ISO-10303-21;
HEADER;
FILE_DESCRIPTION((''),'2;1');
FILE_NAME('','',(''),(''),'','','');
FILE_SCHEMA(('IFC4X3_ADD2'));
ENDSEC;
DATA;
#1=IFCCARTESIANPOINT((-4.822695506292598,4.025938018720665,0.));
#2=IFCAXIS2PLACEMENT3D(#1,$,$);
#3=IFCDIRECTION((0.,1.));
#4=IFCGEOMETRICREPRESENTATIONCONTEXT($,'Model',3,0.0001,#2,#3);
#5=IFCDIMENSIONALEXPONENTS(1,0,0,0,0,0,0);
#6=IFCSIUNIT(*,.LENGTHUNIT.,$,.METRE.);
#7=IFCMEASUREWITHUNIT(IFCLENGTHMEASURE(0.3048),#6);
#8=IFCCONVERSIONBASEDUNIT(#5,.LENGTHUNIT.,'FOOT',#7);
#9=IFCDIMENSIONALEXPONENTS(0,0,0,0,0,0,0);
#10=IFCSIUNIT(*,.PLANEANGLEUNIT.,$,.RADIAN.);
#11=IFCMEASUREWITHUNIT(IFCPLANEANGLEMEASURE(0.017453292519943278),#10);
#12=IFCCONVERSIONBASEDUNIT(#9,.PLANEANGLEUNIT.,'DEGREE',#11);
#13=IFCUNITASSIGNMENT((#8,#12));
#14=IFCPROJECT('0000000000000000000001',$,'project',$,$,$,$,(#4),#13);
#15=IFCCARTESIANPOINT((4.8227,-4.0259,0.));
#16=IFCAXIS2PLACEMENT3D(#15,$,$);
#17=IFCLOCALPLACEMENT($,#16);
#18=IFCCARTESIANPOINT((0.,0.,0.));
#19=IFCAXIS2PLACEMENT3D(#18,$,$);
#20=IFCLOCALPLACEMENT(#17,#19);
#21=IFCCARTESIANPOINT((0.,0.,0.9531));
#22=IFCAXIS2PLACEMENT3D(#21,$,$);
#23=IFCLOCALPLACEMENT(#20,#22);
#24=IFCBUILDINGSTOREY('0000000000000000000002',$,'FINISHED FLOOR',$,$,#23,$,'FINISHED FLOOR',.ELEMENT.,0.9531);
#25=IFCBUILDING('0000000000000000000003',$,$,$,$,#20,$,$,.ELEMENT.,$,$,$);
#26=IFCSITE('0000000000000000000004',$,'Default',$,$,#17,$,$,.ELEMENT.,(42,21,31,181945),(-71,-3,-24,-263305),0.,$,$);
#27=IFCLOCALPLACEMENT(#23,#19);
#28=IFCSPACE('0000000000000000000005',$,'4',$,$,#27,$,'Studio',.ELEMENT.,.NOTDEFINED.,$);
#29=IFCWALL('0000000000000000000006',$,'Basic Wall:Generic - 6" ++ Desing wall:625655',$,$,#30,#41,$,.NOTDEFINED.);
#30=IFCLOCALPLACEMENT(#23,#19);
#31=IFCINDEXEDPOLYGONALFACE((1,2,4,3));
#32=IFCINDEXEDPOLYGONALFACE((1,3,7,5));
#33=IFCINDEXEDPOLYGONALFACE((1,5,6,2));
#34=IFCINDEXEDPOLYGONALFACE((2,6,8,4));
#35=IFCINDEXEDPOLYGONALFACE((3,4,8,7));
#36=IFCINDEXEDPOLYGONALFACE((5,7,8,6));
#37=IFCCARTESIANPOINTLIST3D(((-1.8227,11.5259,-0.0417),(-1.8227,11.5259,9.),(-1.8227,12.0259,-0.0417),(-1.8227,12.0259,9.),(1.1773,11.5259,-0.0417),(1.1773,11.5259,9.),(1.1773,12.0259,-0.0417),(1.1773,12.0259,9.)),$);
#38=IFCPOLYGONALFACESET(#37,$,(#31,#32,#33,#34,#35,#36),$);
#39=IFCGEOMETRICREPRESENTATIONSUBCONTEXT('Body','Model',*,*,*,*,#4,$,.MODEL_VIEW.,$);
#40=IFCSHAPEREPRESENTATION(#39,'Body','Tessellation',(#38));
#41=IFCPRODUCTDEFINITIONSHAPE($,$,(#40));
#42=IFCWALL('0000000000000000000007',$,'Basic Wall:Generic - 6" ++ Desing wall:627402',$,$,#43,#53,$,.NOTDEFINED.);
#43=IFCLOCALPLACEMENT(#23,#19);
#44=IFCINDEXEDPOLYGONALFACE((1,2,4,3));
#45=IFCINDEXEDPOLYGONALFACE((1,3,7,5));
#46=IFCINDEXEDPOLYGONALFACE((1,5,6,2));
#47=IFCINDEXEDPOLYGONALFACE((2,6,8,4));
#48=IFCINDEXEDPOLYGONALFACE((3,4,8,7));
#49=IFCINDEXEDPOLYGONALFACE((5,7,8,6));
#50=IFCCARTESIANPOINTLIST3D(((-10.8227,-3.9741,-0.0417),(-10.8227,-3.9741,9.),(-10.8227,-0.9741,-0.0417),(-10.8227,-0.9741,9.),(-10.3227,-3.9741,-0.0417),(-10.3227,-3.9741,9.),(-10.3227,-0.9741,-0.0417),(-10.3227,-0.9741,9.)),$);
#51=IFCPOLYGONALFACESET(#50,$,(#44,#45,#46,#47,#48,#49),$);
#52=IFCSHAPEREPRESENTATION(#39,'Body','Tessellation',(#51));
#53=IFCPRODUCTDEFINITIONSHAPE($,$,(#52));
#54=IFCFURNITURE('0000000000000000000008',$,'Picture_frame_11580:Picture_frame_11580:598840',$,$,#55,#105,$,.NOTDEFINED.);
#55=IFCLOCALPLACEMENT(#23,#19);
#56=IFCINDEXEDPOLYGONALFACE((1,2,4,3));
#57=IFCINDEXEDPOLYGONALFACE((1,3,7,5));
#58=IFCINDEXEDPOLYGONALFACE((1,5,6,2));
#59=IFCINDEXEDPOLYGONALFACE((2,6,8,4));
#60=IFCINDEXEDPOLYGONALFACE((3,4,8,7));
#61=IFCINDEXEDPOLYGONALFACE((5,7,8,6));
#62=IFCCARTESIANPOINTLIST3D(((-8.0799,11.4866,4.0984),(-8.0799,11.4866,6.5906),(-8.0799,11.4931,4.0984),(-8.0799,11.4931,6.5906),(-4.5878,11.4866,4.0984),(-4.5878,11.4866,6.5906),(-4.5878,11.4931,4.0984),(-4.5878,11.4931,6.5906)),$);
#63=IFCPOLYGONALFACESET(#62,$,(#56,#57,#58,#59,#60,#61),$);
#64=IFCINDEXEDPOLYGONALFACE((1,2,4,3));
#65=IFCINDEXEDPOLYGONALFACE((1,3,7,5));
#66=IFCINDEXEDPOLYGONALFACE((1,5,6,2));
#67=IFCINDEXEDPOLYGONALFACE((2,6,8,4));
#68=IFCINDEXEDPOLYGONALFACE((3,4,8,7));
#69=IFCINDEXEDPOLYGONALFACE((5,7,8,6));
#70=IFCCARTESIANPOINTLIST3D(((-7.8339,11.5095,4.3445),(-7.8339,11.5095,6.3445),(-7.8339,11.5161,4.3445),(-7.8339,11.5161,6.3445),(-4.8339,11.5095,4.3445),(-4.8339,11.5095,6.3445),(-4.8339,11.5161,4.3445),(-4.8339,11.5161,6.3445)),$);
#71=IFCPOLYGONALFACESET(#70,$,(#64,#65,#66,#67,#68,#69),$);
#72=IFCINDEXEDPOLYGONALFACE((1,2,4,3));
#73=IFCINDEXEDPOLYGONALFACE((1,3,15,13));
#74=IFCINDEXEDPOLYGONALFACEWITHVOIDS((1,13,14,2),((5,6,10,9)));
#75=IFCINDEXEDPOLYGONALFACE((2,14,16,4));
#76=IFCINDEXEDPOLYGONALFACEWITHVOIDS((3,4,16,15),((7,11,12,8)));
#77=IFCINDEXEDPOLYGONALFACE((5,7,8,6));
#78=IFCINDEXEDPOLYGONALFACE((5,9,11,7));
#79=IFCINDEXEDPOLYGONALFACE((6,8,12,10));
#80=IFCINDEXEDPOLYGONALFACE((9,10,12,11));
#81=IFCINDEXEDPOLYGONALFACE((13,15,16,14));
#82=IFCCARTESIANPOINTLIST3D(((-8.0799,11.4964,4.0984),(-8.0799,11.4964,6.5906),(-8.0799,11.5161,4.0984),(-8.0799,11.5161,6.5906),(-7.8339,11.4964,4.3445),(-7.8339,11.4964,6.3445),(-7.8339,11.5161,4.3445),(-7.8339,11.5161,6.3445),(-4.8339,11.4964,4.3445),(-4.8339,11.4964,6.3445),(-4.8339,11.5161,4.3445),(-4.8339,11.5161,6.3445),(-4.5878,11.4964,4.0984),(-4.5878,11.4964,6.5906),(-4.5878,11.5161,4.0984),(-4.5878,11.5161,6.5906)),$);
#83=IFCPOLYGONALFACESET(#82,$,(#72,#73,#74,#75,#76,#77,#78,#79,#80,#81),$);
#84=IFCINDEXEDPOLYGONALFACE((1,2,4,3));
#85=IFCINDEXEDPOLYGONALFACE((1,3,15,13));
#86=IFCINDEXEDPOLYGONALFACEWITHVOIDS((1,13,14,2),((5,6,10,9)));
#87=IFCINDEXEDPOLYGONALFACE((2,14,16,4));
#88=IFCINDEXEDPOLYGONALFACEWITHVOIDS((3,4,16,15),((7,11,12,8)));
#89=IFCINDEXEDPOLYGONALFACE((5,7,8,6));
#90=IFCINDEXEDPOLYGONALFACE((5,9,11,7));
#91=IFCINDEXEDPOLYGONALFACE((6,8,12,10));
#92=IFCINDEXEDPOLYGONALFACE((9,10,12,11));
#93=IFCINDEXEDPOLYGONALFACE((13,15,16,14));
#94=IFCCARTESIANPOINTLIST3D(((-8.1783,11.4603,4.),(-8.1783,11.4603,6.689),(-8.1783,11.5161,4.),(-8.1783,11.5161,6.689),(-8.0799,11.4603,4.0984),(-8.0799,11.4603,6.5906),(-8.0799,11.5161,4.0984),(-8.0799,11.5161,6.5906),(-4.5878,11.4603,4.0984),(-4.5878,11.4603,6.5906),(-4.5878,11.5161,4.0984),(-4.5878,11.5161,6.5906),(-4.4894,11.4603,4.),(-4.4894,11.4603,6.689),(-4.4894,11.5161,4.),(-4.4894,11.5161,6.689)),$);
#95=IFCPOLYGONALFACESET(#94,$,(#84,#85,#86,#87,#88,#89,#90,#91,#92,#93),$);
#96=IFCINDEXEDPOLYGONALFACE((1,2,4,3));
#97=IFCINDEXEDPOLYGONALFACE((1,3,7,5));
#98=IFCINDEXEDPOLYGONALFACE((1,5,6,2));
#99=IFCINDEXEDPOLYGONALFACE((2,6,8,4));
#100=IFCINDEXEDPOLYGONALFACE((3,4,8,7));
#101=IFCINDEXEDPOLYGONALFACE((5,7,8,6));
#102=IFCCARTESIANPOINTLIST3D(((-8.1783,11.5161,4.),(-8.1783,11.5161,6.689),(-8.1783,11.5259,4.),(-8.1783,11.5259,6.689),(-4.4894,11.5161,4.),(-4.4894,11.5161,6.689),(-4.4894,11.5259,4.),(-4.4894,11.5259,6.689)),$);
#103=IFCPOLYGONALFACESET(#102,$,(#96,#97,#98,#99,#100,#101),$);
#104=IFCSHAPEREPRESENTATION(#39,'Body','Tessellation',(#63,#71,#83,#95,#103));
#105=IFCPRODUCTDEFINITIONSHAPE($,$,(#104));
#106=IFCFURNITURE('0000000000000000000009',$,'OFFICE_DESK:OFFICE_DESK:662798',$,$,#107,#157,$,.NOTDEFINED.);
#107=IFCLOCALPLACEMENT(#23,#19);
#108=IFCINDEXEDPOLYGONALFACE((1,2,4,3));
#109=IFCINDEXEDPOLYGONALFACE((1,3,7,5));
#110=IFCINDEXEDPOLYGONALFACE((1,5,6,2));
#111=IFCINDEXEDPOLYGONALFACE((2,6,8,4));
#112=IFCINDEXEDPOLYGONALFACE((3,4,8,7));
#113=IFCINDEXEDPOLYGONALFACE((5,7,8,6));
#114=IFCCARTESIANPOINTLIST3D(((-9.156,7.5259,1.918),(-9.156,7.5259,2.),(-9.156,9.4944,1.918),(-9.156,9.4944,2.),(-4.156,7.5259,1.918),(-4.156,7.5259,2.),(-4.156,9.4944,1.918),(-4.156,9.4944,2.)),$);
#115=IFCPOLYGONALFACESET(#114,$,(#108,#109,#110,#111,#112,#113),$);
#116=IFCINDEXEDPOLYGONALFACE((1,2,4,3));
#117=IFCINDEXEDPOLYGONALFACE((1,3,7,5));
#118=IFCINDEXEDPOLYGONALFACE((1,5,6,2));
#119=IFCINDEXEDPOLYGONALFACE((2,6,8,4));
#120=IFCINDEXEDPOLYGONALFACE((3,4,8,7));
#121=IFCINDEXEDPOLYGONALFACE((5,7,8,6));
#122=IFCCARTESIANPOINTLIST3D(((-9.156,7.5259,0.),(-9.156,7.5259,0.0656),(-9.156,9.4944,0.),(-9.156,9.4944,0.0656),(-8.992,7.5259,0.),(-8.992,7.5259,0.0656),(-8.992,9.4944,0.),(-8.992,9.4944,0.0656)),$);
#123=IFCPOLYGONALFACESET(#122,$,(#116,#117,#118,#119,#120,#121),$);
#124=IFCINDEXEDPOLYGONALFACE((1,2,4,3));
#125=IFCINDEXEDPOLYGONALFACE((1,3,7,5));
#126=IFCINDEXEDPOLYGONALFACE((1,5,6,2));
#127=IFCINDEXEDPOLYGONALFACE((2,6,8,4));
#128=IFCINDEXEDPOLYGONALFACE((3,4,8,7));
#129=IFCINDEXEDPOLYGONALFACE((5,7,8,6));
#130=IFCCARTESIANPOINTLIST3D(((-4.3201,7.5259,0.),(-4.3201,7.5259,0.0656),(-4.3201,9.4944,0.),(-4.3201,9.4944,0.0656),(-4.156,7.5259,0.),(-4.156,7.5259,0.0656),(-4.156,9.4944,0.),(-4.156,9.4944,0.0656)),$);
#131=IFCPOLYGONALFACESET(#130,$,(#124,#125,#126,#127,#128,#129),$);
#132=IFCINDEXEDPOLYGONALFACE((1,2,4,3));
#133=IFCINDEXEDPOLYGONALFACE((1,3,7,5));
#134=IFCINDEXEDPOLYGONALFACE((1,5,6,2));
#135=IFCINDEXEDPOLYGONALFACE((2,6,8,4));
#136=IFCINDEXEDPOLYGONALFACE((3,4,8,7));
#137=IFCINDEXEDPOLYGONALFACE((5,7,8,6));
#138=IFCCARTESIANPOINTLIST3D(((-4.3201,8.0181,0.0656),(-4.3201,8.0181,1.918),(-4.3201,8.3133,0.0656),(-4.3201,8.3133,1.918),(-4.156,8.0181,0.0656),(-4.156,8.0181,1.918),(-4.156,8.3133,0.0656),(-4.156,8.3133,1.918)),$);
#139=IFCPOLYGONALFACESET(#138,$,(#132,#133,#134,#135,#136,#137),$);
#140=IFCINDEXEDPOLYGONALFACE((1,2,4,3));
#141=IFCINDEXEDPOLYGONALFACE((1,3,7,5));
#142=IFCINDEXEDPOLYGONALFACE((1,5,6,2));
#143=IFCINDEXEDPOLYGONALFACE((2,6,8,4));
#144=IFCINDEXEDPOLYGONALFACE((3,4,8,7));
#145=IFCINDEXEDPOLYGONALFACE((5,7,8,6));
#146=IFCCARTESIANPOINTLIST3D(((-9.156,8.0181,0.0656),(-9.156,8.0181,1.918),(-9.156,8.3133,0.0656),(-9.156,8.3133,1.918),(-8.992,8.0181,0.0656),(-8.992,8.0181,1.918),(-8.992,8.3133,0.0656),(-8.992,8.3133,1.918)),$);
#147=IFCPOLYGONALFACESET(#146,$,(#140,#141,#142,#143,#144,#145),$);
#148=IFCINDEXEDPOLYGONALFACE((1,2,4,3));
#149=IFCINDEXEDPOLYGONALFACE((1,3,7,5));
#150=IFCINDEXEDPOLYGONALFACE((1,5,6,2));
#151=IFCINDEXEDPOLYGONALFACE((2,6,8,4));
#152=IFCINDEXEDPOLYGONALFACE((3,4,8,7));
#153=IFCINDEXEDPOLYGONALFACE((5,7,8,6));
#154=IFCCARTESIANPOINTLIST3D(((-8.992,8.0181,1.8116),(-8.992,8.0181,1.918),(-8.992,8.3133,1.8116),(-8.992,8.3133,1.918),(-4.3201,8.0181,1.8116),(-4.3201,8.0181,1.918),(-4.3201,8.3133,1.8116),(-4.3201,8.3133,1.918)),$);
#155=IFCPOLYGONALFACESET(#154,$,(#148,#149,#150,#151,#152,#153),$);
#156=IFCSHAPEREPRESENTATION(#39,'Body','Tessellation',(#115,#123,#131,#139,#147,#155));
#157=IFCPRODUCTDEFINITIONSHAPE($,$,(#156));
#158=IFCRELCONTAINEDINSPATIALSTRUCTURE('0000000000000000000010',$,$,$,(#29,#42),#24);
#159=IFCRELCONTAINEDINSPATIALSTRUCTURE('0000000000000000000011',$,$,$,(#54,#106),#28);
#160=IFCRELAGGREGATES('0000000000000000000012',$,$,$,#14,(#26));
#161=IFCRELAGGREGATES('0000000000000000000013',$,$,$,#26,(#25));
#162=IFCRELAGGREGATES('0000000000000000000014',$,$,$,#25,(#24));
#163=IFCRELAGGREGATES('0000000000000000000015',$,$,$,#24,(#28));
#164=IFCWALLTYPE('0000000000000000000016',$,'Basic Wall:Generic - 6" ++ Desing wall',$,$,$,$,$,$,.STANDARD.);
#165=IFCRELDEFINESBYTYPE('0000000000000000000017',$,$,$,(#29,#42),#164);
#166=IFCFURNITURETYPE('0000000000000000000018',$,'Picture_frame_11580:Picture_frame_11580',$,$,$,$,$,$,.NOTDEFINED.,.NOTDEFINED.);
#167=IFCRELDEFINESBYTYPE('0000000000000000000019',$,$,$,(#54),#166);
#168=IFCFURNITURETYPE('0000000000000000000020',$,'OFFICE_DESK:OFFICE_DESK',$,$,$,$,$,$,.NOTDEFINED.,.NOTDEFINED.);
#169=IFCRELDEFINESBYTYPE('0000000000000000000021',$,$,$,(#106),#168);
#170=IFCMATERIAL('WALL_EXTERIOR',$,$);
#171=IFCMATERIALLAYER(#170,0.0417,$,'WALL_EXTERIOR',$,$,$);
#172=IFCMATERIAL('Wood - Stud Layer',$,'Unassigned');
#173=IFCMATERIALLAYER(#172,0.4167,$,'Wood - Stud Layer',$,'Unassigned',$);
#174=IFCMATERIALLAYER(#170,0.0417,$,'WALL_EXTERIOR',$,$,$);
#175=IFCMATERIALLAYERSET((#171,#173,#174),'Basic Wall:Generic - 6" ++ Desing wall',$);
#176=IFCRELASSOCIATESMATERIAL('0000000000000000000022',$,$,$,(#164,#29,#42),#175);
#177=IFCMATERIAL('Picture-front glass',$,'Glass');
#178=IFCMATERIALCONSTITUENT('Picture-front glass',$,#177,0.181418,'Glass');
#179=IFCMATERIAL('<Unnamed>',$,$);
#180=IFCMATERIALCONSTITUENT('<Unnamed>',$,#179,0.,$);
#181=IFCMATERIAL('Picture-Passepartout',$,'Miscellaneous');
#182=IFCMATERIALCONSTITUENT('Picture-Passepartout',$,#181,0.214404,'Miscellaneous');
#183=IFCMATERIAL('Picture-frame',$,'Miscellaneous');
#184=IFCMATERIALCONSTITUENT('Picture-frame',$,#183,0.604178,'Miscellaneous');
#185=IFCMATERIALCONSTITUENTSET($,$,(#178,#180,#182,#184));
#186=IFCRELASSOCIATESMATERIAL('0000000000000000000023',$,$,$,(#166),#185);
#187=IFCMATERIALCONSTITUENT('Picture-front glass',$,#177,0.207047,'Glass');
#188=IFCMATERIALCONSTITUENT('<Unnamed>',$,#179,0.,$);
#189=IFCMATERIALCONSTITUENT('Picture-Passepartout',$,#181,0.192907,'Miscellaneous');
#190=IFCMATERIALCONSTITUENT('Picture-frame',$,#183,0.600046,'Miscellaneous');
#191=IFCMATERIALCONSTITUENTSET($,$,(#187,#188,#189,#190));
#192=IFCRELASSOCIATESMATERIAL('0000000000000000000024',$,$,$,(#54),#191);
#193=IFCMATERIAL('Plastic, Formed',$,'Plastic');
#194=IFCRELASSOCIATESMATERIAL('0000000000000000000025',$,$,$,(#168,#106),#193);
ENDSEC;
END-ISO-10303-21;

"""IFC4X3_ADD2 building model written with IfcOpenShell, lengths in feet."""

from ifc_helpers import new_model, entity, si_unit, converted_unit, direction, frame, frame_2d, origin, origin_2d_with_axis, place, context, subcontext, project, spatial, polyline, rectangle, outline, extrude, source, transform, mapped, material, layer, layer_set, constituent, constituent_set, type_object, type_shapes, element, save


model = new_model("IFC4X3_ADD2")

# Units and contexts
model_context = context("Model", 3, precision=0.0001, world=frame((-4.822695506292598, 4.025938018720665, 0.0)), true_north=direction((0.0, 1.0)))
body_context = subcontext(model_context, "Body", "Model", "MODEL_VIEW")
ifc_project = project(units=[converted_unit("LENGTHUNIT", "FOOT", entity("IfcLengthMeasure", 0.3048), si_unit("LENGTHUNIT", "METRE"), dimensions=[1, 0, 0, 0, 0, 0, 0]), converted_unit("PLANEANGLEUNIT", "DEGREE", entity("IfcPlaneAngleMeasure", 0.017453292519943278), si_unit("PLANEANGLEUNIT", "RADIAN"), dimensions=[0, 0, 0, 0, 0, 0, 0])], contexts=[model_context])

# Site, building, storey
site_placement = place(None, frame((4.8227, -4.0259, 0.0)))
site = spatial("IfcSite", under=ifc_project, at=site_placement, Name="Default", CompositionType="ELEMENT", RefLatitude=(42, 21, 31, 181945), RefLongitude=(-71, -3, -24, -263305), RefElevation=0.0)
building_placement = place(site_placement, origin())
building = spatial("IfcBuilding", under=site, at=building_placement, CompositionType="ELEMENT")
storey_placement = place(building_placement, frame((0.0, 0.0, 0.9531)))
storey = spatial("IfcBuildingStorey", under=building, at=storey_placement, Name="FINISHED FLOOR", LongName="FINISHED FLOOR", CompositionType="ELEMENT", Elevation=0.9531)

# Shared definitions
ifc_material_1 = material(Name="WALL_EXTERIOR")
ifc_material_2 = material(Name="Wood - Stud Layer", Category="Unassigned")

# Walls
ifc_layer_1 = layer(ifc_material_1, 0.0417, Name="WALL_EXTERIOR")
ifc_layer_2 = layer(ifc_material_2, 0.4167, Name="Wood - Stud Layer", Category="Unassigned")
ifc_layer_3 = layer(ifc_material_1, 0.0417, Name="WALL_EXTERIOR")
ifc_layer_set_1 = layer_set([ifc_layer_1, ifc_layer_2, ifc_layer_3], Name="Basic Wall:Generic - 6\" ++ Desing wall")
wall_type_1 = type_object("IfcWallType", Name="Basic Wall:Generic - 6\" ++ Desing wall", PredefinedType="STANDARD", material=ifc_layer_set_1)
wall_1_placement = place(storey_placement, frame((-1.8227, 11.7759, -0.0417)))
element("IfcWall", 1, at=wall_1_placement, inside=storey, type_object=wall_type_1, material=ifc_layer_set_1, Name="Basic Wall:Generic - 6\" ++ Desing wall:625655", PredefinedType="NOTDEFINED", context=body_context, shape_type="SweptSolid", body=[
    extrude(rectangle(XDim=3.0, YDim=0.5, at=frame_2d((1.5, 0.0), x_axis=(-1.0, 0.0))), origin(), (0.0, 0.0, 1.0), 9.0417),
])
wall_2_placement = place(storey_placement, frame((-10.5727, -0.9741, -0.0417), z_axis=(0.0, 0.0, 1.0), x_axis=(0.0, -1.0, 0.0)))
element("IfcWall", 2, at=wall_2_placement, inside=storey, type_object=wall_type_1, material=ifc_layer_set_1, Name="Basic Wall:Generic - 6\" ++ Desing wall:627402", PredefinedType="NOTDEFINED", context=body_context, shape_type="SweptSolid", body=[
    extrude(rectangle(XDim=3.0, YDim=0.5, at=frame_2d((1.5, 0.0), x_axis=(-1.0, 0.0))), origin(), (0.0, 0.0, 1.0), 9.0417),
])

# Shared definitions
space_placement = place(storey_placement, origin())
space = spatial("IfcSpace", under=storey, at=space_placement, Name="4", LongName="Studio", CompositionType="ELEMENT", PredefinedType="NOTDEFINED")

# Furniture
ifc_material_3 = material(Name="Picture-front glass", Category="Glass")
ifc_constituent_1 = constituent(ifc_material_3, Name="Picture-front glass", Category="Glass", fraction=0.207047)
ifc_material_4 = material(Name="<Unnamed>")
ifc_constituent_2 = constituent(ifc_material_4, Name="<Unnamed>", fraction=0.0)
ifc_material_5 = material(Name="Picture-Passepartout", Category="Miscellaneous")
ifc_constituent_3 = constituent(ifc_material_5, Name="Picture-Passepartout", Category="Miscellaneous", fraction=0.192907)
ifc_material_6 = material(Name="Picture-frame", Category="Miscellaneous")
ifc_constituent_4 = constituent(ifc_material_6, Name="Picture-frame", Category="Miscellaneous", fraction=0.600046)
ifc_constituent_set_1 = constituent_set(constituents=[ifc_constituent_1, ifc_constituent_2, ifc_constituent_3, ifc_constituent_4])
ifc_constituent_5 = constituent(ifc_material_3, Name="Picture-front glass", Category="Glass", fraction=0.181418)
ifc_constituent_6 = constituent(ifc_material_4, Name="<Unnamed>", fraction=0.0)
ifc_constituent_7 = constituent(ifc_material_5, Name="Picture-Passepartout", Category="Miscellaneous", fraction=0.214404)
ifc_constituent_8 = constituent(ifc_material_6, Name="Picture-frame", Category="Miscellaneous", fraction=0.604178)
ifc_constituent_set_2 = constituent_set(constituents=[ifc_constituent_5, ifc_constituent_6, ifc_constituent_7, ifc_constituent_8])
furniture_type_1 = type_object("IfcFurnitureType", Name="Picture_frame_11580:Picture_frame_11580", AssemblyPlace="NOTDEFINED", PredefinedType="NOTDEFINED", material=ifc_constituent_set_2)
shared_shape_1 = source(origin(), body_context, "Body", "SweptSolid", [
    extrude(rectangle(XDim=0.0066, YDim=3.4921, at=frame_2d((0.0, 0.0), x_axis=(1.0, 0.0))), frame((1.8445, -0.0361, 0.0984), z_axis=(0.0, 0.0, 1.0), x_axis=(0.0, 1.0, 0.0)), (0.0, 0.0, 1.0), 2.4921),
    extrude(rectangle(XDim=0.0066, YDim=3.0, at=origin_2d_with_axis()), frame((1.8445, -0.0131, 0.3445), z_axis=(0.0, 0.0, 1.0), x_axis=(0.0, 1.0, 0.0)), (0.0, 0.0, 1.0), 2.0),
    extrude(outline(polyline([(-1.2461, -1.7461), (1.2461, -1.7461), (1.2461, 1.7461), (-1.2461, 1.7461), (-1.2461, -1.7461)]), holes=[polyline([(-1.0, -1.5), (-1.0, 1.5), (1.0, 1.5), (1.0, -1.5), (-1.0, -1.5)])]), frame((1.8445, -0.0295, 1.3445), z_axis=(0.0, 1.0, 0.0), x_axis=(0.0, 0.0, -1.0)), (0.0, 0.0, 1.0), 0.0197),
    extrude(outline(polyline([(-1.8445, -1.3445), (1.8445, -1.3445), (1.8445, 1.3445), (-1.8445, 1.3445), (-1.8445, -1.3445)]), holes=[polyline([(1.7461, -1.2461), (-1.7461, -1.2461), (-1.7461, 1.2461), (1.7461, 1.2461), (1.7461, -1.2461)])]), frame((1.8445, -0.0656, 1.3445), z_axis=(0.0, 1.0, 0.0), x_axis=(1.0, 0.0, 0.0)), (0.0, 0.0, 1.0), 0.0558),
    extrude(rectangle(XDim=0.0098, YDim=3.689, at=origin_2d_with_axis()), frame((1.8445, -0.0049, 0.0), z_axis=(0.0, 0.0, 1.0), x_axis=(0.0, 1.0, 0.0)), (0.0, 0.0, 1.0), 2.689),
])
type_shapes(furniture_type_1, [shared_shape_1])
furniture_1_placement = place(space_placement, frame((-8.1783, 11.5259, 4.0)))
element("IfcFurniture", 3, at=furniture_1_placement, inside=space, type_object=furniture_type_1, material=ifc_constituent_set_1, Name="Picture_frame_11580:Picture_frame_11580:598840", PredefinedType="NOTDEFINED", context=body_context, shape_type="MappedRepresentation", body=[
    mapped(shared_shape_1, transform((0.0, 0.0, 0.0), scale=1.0)),
])
ifc_material_7 = material(Name="Plastic, Formed", Category="Plastic")
furniture_type_2 = type_object("IfcFurnitureType", Name="OFFICE_DESK:OFFICE_DESK", AssemblyPlace="NOTDEFINED", PredefinedType="NOTDEFINED", material=ifc_material_7)
shared_shape_2 = source(origin(), body_context, "Body", "SweptSolid", [
    extrude(rectangle(XDim=1.9685, YDim=5.0, at=origin_2d_with_axis()), frame((0.0, -0.9843, 1.918), z_axis=(0.0, 0.0, 1.0), x_axis=(0.0, -1.0, 0.0)), (0.0, 0.0, 1.0), 0.082),
    extrude(rectangle(XDim=0.164, YDim=1.9685, at=origin_2d_with_axis()), frame((2.418, -0.9843, 0.0)), (0.0, 0.0, 1.0), 0.0656),
    extrude(rectangle(XDim=1.9685, YDim=0.164, at=origin_2d_with_axis()), frame((-2.418, -0.9843, 0.0), z_axis=(0.0, 0.0, 1.0), x_axis=(0.0, 1.0, 0.0)), (0.0, 0.0, 1.0), 0.0656),
    extrude(rectangle(XDim=0.2953, YDim=0.164, at=frame_2d((0.0, 0.0), x_axis=(1.0, 0.0))), frame((-2.418, -0.6398, 0.0656), z_axis=(0.0, 0.0, 1.0), x_axis=(0.0, -1.0, 0.0)), (0.0, 0.0, 1.0), 1.8524),
    extrude(rectangle(XDim=0.164, YDim=0.2953, at=origin_2d_with_axis()), frame((2.418, -0.6398, 0.0656), z_axis=(0.0, 0.0, 1.0), x_axis=(-1.0, 0.0, 0.0)), (0.0, 0.0, 1.0), 1.8524),
    extrude(rectangle(XDim=0.2953, YDim=4.6719, at=origin_2d_with_axis()), frame((0.0, -0.6398, 1.8116), z_axis=(0.0, 0.0, 1.0), x_axis=(0.0, 1.0, 0.0)), (0.0, 0.0, 1.0), 0.1064),
])
type_shapes(furniture_type_2, [shared_shape_2])
furniture_2_placement = place(space_placement, frame((-6.656, 7.5259, 0.0), z_axis=(0.0, 0.0, 1.0), x_axis=(-1.0, 0.0, 0.0)))
element("IfcFurniture", 4, at=furniture_2_placement, inside=space, type_object=furniture_type_2, material=ifc_material_7, Name="OFFICE_DESK:OFFICE_DESK:662798", PredefinedType="NOTDEFINED", context=body_context, shape_type="MappedRepresentation", body=[
    mapped(shared_shape_2, transform((0.0, 0.0, 0.0), scale=1.0)),
])

save(model, "model.ifc")
